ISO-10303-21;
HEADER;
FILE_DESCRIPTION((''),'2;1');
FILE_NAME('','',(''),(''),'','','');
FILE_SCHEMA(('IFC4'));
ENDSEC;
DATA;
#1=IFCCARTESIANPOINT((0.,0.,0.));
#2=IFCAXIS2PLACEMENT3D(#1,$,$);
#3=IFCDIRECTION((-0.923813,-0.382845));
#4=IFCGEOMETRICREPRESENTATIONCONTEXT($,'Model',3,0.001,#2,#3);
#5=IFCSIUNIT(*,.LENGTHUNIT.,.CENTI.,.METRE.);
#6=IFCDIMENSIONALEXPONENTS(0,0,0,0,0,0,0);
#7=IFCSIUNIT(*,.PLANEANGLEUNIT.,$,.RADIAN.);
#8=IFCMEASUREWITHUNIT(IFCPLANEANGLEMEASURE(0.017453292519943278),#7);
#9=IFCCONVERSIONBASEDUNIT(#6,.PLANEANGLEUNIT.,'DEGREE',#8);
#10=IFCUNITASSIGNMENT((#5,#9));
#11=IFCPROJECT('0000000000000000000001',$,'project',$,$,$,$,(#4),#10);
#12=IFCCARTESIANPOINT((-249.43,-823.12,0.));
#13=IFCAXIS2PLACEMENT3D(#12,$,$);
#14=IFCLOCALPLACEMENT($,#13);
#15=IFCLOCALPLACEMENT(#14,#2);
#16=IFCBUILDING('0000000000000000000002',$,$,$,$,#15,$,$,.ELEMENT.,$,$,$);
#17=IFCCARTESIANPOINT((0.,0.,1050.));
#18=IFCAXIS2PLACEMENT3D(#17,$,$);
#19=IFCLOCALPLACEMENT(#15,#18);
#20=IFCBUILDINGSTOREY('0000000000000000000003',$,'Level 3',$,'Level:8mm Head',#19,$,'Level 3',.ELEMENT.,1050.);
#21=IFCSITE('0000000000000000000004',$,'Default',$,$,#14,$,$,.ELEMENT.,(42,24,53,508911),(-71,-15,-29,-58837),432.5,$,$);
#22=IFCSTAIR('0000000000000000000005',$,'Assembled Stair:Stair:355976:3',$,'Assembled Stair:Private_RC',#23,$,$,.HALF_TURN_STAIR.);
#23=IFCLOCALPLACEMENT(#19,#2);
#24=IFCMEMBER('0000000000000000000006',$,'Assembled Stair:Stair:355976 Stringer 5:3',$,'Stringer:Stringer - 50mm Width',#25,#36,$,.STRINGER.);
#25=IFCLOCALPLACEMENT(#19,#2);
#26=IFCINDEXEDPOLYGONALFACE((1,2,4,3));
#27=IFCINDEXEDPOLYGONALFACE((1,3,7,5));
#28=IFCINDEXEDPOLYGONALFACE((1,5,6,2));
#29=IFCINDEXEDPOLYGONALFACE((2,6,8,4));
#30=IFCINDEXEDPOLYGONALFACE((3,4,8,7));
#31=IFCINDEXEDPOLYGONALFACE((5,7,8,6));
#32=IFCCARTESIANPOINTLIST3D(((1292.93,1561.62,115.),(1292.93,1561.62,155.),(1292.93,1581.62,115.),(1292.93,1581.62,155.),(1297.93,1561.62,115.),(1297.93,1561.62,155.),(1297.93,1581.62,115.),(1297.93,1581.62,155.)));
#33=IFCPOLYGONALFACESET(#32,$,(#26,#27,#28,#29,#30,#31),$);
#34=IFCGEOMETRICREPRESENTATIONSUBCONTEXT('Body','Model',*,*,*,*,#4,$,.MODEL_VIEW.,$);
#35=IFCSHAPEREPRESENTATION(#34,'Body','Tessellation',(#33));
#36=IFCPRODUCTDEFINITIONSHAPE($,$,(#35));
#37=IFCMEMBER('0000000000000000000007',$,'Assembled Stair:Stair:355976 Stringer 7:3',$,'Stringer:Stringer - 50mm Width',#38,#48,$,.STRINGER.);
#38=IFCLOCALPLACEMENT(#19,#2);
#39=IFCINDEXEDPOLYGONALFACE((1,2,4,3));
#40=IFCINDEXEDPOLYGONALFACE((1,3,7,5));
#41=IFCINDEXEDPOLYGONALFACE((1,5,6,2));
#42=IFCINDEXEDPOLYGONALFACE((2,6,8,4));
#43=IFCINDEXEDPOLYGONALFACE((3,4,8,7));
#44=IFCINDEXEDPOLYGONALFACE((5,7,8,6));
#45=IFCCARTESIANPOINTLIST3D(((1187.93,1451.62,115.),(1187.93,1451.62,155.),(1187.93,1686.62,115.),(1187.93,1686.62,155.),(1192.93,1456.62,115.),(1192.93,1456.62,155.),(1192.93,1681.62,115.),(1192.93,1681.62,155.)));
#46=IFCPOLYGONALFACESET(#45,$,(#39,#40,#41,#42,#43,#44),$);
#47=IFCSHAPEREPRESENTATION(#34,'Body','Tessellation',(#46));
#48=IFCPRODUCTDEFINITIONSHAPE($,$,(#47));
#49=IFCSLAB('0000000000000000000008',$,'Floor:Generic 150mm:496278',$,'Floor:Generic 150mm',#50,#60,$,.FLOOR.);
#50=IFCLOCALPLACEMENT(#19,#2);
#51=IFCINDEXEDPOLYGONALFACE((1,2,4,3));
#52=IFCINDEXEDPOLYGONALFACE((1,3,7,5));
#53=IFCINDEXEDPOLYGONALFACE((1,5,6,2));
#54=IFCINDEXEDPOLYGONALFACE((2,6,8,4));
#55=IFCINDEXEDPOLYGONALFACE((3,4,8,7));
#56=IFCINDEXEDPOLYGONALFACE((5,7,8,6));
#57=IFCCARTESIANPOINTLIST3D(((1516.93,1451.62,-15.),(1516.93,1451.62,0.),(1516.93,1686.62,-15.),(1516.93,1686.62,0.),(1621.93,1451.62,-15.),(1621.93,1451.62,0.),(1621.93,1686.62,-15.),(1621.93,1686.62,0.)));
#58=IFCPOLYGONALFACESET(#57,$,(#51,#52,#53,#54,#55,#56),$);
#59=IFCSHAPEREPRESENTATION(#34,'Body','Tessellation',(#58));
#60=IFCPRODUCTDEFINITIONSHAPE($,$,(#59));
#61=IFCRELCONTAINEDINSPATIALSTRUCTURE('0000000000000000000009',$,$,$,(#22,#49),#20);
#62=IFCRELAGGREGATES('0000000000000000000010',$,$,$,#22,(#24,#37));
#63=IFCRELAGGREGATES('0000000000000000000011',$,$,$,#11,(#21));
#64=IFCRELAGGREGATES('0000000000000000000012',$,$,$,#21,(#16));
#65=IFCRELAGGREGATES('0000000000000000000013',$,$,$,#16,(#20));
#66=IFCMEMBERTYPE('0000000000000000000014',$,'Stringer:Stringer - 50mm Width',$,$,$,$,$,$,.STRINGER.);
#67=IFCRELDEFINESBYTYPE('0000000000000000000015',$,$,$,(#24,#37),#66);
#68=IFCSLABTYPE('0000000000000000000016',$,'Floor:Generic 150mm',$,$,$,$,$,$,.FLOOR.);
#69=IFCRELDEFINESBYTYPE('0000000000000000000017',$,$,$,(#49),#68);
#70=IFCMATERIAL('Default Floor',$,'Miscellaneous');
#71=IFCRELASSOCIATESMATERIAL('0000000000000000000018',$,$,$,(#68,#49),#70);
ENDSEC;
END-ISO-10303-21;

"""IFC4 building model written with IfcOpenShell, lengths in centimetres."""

from ifc_helpers import new_model, entity, si_unit, converted_unit, direction, frame, origin, place, context, subcontext, project, spatial, indexed_curve, outline, extrude, material, type_object, element, aggregate, save


model = new_model("IFC4")

# Units and contexts
model_context = context("Model", 3, precision=0.001, world=origin(), true_north=direction((-0.923813, -0.382845)))
body_context = subcontext(model_context, "Body", "Model", "MODEL_VIEW")
ifc_project = project(units=[si_unit("LENGTHUNIT", "METRE", prefix="CENTI"), converted_unit("PLANEANGLEUNIT", "DEGREE", entity("IfcPlaneAngleMeasure", 0.017453292519943278), si_unit("PLANEANGLEUNIT", "RADIAN"), dimensions=[0, 0, 0, 0, 0, 0, 0])], contexts=[model_context])

# Site, building, storey
site_placement = place(None, frame((-249.43, -823.12, 0.0)))
site = spatial("IfcSite", under=ifc_project, at=site_placement, Name="Default", CompositionType="ELEMENT", RefLatitude=(42, 24, 53, 508911), RefLongitude=(-71, -15, -29, -58837), RefElevation=432.5)
building_placement = place(site_placement, origin())
building = spatial("IfcBuilding", under=site, at=building_placement, CompositionType="ELEMENT")
storey_placement = place(building_placement, frame((0.0, 0.0, 1050.0)))
storey = spatial("IfcBuildingStorey", under=building, at=storey_placement, Name="Level 3", ObjectType="Level:8mm Head", LongName="Level 3", CompositionType="ELEMENT", Elevation=1050.0)

# Stair, members
stair_placement = place(storey_placement, origin())
stair = element("IfcStair", 1, at=stair_placement, inside=storey, Name="Assembled Stair:Stair:355976:3", ObjectType="Assembled Stair:Private_RC", PredefinedType="HALF_TURN_STAIR")
member_type = type_object("IfcMemberType", Name="Stringer:Stringer - 50mm Width", PredefinedType="STRINGER")
member_1_placement = place(stair_placement, origin())
member_1 = element("IfcMember", 2, at=member_1_placement, type_object=member_type, Name="Assembled Stair:Stair:355976 Stringer 5:3", ObjectType="Stringer:Stringer - 50mm Width", PredefinedType="STRINGER", context=body_context, shape_type="SweptSolid", body=[
    extrude(outline(indexed_curve([(-10.0, -2.5), (10.0, -2.5), (10.0, 2.5), (-10.0, 2.5), (-10.0, -2.5)], self_intersect=False)), frame((1295.43, 1571.62, 115.0), z_axis=(0.0, 0.0, 1.0), x_axis=(0.0, 1.0, 0.0)), (0.0, 0.0, 1.0), 40.0),
])
member_2_placement = place(stair_placement, origin())
member_2 = element("IfcMember", 3, at=member_2_placement, type_object=member_type, Name="Assembled Stair:Stair:355976 Stringer 7:3", ObjectType="Stringer:Stringer - 50mm Width", PredefinedType="STRINGER", context=body_context, shape_type="SweptSolid", body=[
    extrude(outline(indexed_curve([(-117.5, -2.5), (117.5, -2.5), (112.5, 2.5), (-112.5, 2.5), (-117.5, -2.5)], self_intersect=False)), frame((1190.43, 1569.12, 115.0), z_axis=(0.0, 0.0, 1.0), x_axis=(0.0, -1.0, 0.0)), (0.0, 0.0, 1.0), 40.0),
])

# Slab
ifc_material_1 = material(Name="Default Floor", Category="Miscellaneous")
slab_type_1 = type_object("IfcSlabType", Name="Floor:Generic 150mm", PredefinedType="FLOOR", material=ifc_material_1)
slab_1_placement = place(storey_placement, origin())
element("IfcSlab", 4, at=slab_1_placement, inside=storey, type_object=slab_type_1, material=ifc_material_1, Name="Floor:Generic 150mm:496278", ObjectType="Floor:Generic 150mm", PredefinedType="FLOOR", context=body_context, shape_type="SweptSolid", body=[
    extrude(outline(indexed_curve([(-117.5, -52.5), (117.5, -52.5), (117.5, 52.5), (-117.5, 52.5), (-117.5, -52.5)], self_intersect=False)), frame((1569.43, 1569.12, 0.0), z_axis=(0.0, 0.0, -1.0), x_axis=(0.0, 1.0, 0.0)), (0.0, 0.0, 1.0), 15.0),
])

aggregate(stair, [member_1, member_2])

save(model, "model.ifc")
